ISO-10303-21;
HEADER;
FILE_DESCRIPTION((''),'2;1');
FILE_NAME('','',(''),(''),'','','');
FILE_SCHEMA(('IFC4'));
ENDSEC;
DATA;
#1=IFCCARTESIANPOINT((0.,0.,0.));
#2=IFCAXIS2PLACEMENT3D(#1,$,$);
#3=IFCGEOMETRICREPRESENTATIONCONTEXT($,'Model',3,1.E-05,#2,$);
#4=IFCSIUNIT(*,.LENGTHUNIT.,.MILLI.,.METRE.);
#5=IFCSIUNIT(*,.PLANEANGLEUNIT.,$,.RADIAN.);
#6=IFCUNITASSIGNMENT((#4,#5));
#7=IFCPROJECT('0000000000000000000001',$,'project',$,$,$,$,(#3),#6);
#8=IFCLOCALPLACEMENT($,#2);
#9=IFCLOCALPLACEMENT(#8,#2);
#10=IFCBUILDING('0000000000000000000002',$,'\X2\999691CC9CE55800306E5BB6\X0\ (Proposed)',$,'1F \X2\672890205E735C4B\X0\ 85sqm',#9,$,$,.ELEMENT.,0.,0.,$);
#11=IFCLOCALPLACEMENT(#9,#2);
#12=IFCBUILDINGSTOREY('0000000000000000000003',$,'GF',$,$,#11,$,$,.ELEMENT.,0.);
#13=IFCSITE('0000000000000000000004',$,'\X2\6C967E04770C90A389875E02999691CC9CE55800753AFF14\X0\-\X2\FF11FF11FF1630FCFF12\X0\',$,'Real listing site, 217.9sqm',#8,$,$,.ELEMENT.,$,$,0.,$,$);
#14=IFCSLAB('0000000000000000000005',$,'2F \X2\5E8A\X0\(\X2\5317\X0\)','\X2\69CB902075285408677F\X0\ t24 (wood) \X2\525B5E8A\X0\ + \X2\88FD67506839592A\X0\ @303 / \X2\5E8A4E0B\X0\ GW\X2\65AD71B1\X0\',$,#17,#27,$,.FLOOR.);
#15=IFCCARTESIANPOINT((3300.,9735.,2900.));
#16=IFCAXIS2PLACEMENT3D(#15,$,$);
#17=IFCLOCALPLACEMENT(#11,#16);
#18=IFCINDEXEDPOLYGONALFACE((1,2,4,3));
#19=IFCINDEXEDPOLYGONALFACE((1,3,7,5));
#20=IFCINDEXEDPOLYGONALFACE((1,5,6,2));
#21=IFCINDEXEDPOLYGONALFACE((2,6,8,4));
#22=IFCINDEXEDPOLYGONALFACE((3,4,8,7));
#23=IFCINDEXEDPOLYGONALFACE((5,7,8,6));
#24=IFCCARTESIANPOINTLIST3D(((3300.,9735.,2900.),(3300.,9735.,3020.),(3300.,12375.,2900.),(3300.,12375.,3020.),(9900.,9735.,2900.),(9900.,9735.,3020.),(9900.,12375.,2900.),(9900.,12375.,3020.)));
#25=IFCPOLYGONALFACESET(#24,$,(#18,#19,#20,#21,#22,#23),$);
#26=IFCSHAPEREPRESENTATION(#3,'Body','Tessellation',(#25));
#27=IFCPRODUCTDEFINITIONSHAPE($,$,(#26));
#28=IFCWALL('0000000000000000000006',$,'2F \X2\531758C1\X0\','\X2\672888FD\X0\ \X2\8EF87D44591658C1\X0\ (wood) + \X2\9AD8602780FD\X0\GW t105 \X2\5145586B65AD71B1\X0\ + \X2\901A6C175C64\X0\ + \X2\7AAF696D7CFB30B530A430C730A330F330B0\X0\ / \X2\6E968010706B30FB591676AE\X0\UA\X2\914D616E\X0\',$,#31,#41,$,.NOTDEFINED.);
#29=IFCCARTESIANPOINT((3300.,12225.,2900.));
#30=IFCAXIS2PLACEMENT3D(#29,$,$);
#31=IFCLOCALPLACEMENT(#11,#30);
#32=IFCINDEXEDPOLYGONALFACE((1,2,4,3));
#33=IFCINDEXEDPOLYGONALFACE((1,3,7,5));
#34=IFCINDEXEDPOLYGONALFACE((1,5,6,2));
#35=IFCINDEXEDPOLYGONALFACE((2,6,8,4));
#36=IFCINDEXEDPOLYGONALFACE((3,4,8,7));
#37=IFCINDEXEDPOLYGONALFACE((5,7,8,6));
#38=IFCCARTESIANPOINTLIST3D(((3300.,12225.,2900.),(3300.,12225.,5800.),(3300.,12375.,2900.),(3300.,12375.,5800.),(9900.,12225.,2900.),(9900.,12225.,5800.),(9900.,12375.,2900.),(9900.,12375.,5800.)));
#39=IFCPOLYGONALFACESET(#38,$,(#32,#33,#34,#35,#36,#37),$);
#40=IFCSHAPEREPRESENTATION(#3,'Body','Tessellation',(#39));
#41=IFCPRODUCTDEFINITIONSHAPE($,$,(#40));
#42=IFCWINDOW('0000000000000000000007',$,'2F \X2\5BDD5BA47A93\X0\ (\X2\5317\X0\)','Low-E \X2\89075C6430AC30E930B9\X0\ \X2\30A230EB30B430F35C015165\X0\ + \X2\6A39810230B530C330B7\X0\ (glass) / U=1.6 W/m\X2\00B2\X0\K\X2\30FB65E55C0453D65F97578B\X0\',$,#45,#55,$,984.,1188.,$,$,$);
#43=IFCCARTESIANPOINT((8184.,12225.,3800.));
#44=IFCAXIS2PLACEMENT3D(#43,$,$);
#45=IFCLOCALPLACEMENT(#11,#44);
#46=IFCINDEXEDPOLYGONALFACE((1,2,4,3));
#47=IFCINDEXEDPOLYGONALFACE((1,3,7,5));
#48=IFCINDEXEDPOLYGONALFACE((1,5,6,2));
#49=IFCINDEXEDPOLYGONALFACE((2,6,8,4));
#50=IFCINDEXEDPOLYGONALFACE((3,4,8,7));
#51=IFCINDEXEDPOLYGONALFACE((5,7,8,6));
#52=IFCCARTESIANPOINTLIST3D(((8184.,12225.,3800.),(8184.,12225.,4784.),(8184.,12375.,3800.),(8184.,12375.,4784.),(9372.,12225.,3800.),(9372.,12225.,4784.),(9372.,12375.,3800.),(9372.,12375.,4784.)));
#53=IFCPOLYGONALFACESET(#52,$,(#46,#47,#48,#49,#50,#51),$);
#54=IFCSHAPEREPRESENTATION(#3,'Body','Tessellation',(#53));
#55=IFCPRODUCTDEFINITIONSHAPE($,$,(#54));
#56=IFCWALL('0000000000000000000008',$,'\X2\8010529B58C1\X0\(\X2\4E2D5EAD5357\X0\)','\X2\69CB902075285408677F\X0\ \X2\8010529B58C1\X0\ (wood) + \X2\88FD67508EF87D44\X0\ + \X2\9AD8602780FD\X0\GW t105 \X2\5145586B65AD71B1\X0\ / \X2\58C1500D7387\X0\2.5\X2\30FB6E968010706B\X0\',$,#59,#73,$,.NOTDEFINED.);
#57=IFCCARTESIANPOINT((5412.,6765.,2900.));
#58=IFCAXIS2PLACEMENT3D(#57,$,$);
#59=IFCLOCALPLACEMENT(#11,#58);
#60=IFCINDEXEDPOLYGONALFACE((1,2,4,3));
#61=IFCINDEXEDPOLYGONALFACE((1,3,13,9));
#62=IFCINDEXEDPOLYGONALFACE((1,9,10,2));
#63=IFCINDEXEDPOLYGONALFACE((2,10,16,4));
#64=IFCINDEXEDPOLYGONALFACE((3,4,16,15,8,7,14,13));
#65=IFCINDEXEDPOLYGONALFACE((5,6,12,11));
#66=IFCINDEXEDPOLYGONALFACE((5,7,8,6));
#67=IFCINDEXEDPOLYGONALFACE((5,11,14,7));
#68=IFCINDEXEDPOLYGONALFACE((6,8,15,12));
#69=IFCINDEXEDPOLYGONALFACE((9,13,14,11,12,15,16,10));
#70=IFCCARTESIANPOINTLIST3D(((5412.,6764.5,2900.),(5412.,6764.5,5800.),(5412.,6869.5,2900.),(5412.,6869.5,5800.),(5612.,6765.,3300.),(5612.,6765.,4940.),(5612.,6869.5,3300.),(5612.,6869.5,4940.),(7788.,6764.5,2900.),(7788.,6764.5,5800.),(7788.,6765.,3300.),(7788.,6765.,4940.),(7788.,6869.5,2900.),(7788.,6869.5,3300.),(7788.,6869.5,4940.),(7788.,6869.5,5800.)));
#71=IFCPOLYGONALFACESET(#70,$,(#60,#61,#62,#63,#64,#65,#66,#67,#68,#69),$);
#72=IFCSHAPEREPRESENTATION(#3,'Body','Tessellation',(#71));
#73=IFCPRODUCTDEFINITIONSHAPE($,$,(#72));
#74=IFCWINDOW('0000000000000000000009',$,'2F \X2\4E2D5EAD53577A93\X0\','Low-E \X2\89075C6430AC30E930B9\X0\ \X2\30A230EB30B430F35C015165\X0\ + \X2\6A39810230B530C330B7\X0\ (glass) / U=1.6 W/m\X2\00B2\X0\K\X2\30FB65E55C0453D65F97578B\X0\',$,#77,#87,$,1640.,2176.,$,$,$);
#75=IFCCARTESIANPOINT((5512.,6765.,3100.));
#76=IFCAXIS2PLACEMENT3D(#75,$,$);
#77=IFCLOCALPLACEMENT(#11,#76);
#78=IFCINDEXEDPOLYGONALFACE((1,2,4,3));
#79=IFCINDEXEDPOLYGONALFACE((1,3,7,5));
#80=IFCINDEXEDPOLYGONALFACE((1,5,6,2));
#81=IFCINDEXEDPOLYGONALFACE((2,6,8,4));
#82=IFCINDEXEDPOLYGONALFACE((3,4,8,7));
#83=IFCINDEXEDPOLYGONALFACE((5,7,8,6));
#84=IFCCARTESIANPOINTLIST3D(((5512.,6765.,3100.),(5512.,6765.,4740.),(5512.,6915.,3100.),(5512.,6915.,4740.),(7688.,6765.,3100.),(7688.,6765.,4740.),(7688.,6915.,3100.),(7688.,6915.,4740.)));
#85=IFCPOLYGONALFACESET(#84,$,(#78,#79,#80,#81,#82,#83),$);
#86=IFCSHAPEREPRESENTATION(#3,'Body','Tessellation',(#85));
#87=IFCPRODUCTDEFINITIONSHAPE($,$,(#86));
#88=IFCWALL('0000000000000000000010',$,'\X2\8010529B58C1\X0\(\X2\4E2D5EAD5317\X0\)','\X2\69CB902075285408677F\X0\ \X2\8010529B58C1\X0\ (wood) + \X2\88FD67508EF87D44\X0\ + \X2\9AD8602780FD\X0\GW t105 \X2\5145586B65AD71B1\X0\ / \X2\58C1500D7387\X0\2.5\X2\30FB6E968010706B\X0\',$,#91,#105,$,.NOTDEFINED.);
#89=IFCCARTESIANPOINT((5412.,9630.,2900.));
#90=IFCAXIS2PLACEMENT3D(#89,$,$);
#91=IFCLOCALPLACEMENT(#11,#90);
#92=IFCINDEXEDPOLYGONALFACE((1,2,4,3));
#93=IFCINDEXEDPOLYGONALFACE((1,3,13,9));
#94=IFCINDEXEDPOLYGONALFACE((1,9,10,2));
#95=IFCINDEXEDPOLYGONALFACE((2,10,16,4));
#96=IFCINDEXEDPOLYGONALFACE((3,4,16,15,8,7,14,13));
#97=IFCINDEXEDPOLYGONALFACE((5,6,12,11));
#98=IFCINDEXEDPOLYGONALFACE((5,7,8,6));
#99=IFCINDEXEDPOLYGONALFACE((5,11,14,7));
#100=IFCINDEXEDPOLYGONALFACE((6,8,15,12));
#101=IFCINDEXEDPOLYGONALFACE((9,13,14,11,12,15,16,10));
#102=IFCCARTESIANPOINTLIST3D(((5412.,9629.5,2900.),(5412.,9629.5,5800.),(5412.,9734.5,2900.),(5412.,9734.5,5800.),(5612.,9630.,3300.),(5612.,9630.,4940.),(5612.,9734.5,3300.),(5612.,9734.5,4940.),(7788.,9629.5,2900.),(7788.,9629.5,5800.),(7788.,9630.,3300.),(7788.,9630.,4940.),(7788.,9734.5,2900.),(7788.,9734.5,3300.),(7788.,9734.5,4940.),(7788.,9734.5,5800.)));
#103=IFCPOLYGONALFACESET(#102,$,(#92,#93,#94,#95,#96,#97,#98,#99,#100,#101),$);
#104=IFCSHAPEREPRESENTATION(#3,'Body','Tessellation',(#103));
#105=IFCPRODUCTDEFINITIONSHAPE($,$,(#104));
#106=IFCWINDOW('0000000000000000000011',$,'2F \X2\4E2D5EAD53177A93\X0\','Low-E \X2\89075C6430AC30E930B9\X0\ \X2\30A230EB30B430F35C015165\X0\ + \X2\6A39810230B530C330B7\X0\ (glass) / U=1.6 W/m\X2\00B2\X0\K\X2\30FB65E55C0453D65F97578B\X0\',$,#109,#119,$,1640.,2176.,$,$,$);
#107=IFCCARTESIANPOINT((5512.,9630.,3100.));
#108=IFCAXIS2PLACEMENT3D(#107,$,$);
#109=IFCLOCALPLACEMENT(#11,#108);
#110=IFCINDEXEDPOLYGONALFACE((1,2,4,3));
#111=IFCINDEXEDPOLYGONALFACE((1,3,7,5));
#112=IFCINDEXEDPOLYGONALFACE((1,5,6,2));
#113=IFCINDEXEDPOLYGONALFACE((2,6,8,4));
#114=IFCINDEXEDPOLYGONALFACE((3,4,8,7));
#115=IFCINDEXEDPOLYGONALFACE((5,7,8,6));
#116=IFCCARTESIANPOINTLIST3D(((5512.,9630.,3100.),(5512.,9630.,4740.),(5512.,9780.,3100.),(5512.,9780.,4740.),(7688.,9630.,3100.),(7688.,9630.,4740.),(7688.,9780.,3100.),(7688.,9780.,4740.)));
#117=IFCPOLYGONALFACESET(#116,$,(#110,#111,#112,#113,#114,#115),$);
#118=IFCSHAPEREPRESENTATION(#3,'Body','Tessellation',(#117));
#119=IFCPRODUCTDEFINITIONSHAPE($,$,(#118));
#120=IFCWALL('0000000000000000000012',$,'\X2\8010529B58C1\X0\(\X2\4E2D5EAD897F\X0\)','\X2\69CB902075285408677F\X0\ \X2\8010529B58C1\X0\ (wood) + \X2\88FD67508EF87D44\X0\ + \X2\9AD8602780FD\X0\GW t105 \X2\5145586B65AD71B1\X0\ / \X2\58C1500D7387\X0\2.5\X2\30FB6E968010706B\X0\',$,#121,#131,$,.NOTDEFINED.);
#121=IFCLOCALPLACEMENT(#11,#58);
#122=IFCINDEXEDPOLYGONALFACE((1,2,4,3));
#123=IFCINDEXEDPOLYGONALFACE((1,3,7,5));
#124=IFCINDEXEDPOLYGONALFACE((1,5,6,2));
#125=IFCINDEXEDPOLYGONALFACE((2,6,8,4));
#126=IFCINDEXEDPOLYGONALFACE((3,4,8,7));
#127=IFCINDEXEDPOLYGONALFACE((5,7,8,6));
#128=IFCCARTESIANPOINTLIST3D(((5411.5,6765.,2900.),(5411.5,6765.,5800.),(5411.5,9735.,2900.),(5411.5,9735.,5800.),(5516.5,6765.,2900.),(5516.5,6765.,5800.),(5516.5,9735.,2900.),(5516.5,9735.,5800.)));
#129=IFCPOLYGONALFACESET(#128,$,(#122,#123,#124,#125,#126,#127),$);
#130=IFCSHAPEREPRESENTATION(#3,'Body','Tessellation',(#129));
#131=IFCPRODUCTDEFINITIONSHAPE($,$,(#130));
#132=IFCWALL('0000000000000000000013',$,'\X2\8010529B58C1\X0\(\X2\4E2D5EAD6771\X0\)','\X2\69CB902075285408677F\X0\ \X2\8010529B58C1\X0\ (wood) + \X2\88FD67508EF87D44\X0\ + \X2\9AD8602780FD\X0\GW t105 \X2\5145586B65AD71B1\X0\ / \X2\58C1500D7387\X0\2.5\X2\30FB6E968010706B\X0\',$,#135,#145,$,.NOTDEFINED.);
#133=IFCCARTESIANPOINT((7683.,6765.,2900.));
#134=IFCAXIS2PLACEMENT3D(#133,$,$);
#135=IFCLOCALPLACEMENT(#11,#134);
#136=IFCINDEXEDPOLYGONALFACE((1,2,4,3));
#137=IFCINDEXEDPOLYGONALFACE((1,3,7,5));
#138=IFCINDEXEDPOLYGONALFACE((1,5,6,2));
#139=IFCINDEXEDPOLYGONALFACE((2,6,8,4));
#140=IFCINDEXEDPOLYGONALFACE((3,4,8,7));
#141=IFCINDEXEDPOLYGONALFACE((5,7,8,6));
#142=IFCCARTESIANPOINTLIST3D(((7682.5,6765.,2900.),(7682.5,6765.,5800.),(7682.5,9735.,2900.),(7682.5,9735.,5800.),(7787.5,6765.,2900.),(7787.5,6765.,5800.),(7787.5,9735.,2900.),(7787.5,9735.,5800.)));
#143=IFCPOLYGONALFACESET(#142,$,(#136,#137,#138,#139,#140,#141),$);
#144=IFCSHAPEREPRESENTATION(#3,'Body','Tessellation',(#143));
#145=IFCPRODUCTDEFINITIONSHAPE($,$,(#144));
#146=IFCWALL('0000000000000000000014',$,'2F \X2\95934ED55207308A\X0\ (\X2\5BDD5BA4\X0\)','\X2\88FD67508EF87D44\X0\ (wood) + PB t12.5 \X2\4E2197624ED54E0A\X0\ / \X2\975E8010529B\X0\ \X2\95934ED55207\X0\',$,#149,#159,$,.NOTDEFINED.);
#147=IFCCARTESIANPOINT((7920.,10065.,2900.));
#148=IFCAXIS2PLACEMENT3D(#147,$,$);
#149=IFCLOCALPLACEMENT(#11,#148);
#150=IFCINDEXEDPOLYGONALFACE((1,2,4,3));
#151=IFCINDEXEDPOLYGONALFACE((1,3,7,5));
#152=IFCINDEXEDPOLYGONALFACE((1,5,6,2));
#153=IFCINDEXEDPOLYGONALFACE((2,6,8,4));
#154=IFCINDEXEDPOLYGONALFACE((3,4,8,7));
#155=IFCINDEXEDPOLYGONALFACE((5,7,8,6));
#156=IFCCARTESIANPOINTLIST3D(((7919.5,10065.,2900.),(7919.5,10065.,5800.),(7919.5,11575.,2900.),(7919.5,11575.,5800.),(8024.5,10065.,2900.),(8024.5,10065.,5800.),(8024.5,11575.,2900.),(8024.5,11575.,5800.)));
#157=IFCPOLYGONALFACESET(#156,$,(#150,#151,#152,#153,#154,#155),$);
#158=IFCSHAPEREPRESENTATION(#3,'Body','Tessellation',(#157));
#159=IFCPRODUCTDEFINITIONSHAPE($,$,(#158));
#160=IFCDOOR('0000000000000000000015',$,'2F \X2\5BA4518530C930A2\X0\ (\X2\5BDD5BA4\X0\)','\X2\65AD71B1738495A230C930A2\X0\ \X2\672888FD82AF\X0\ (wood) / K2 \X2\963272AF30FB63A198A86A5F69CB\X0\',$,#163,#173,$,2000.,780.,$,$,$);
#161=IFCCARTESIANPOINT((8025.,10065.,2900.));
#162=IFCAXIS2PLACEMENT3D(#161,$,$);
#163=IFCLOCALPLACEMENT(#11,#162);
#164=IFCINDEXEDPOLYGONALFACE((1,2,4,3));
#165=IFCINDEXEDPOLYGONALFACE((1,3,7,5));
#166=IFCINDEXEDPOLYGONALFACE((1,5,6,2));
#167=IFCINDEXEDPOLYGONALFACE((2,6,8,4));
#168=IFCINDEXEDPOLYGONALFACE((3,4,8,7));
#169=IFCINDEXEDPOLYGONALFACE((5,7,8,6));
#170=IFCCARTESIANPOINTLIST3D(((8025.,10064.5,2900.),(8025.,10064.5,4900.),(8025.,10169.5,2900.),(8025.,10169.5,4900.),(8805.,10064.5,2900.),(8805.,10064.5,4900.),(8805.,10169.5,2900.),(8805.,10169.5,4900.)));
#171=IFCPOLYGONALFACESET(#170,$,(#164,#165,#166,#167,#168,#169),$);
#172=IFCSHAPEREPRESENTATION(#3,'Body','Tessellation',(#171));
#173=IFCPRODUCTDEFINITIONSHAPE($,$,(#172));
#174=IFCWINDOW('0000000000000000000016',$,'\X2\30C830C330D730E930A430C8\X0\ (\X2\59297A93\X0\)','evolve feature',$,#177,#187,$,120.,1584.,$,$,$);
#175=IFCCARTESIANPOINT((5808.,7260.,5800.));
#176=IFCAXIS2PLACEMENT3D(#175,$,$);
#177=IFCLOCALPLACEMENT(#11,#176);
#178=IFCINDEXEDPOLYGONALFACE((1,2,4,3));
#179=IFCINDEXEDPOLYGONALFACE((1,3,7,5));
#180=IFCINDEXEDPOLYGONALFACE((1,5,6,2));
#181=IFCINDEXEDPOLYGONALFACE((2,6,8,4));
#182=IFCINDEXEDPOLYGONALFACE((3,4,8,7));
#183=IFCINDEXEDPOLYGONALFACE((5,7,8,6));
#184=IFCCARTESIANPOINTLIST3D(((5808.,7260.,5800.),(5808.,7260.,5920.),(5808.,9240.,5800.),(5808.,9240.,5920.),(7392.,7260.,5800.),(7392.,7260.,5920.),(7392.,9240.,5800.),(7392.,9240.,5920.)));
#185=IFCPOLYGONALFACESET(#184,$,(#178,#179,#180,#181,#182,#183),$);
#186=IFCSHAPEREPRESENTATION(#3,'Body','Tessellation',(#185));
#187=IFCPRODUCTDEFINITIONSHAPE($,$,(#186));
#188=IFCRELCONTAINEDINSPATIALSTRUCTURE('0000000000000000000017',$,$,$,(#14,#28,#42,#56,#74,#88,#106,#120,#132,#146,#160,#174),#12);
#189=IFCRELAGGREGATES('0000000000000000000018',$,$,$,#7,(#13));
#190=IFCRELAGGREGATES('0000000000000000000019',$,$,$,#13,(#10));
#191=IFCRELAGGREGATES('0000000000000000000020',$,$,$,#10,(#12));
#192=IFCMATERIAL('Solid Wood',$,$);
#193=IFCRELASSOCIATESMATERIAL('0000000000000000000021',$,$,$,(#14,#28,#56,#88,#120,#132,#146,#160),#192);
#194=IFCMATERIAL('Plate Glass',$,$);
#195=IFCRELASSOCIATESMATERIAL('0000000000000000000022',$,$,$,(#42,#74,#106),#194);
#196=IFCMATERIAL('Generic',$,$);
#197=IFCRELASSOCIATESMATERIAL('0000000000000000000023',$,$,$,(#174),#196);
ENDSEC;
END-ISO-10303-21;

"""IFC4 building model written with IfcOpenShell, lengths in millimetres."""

from ifc_helpers import new_model, si_unit, frame, frame_2d, origin, place, context, project, spatial, rectangle, extrude, material, element, fill, save


model = new_model("IFC4")

# Units and contexts
model_context = context("Model", 3, precision=1e-05, world=origin())
ifc_project = project(units=[si_unit("LENGTHUNIT", "METRE", prefix="MILLI"), si_unit("PLANEANGLEUNIT", "RADIAN")], contexts=[model_context])

# Site, building, storey
site_placement = place(None, origin())
site = spatial("IfcSite", under=ifc_project, at=site_placement, Name="沖縄県那覇市首里鳥堀町４-１１６ー２", ObjectType="Real listing site, 217.9sqm", CompositionType="ELEMENT", RefElevation=0.0)
building_placement = place(site_placement, origin())
building = spatial("IfcBuilding", under=site, at=building_placement, Name="首里鳥堀の家 (Proposed)", ObjectType="1F 木造平屋 85sqm", CompositionType="ELEMENT", ElevationOfRefHeight=0.0, ElevationOfTerrain=0.0)
storey_placement = place(building_placement, origin())
storey = spatial("IfcBuildingStorey", under=building, at=storey_placement, Name="GF", CompositionType="ELEMENT", Elevation=0.0)

# Slab
ifc_material_1 = material(Name="Solid Wood")
slab_placement = place(storey_placement, frame((3300.0, 9735.0, 2900.0)))
element("IfcSlab", 1, at=slab_placement, inside=storey, material=ifc_material_1, Name="2F 床(北)", Description="構造用合板 t24 (wood) 剛床 + 製材根太 @303 / 床下 GW断熱", PredefinedType="FLOOR", context=model_context, shape_type="SweptSolid", body=[
    extrude(rectangle(XDim=6600.0, YDim=2640.0, at=frame_2d((3300.0, 1320.0))), frame((3300.0, 9735.0, 2900.0)), (0.0, 0.0, 1.0), 120.0),
])

# Walls, openings, windows
wall_1_placement = place(storey_placement, frame((3300.0, 12225.0, 2900.0)))
wall_1 = element("IfcWall", 2, at=wall_1_placement, inside=storey, material=ifc_material_1, Name="2F 北壁", Description="木製 軸組外壁 (wood) + 高性能GW t105 充填断熱 + 通気層 + 窯業系サイディング / 準耐火・外皮UA配慮", PredefinedType="NOTDEFINED", context=model_context, shape_type="SweptSolid", body=[
    extrude(rectangle(XDim=6600.0, YDim=150.0, at=frame_2d((3300.0, 75.0))), frame((3300.0, 12225.0, 2900.0)), (0.0, 0.0, 1.0), 2900.0),
])
opening_1_placement = place(storey_placement, frame((8184.0, 12225.0, 3800.0)))
opening_1 = element("IfcOpeningElement", 3, at=opening_1_placement, cuts=wall_1, PredefinedType="NOTDEFINED", context=model_context, shape_type="SweptSolid", body=[
    extrude(rectangle(XDim=1188.0, YDim=150.0, at=frame_2d((594.0, 75.0))), frame((8184.0, 12225.0, 3800.0)), (0.0, 0.0, 1.0), 984.0),
])
ifc_material_2 = material(Name="Plate Glass")
window_1_placement = place(storey_placement, frame((8184.0, 12225.0, 3800.0)))
window_1 = element("IfcWindow", 4, at=window_1_placement, inside=storey, material=ifc_material_2, Name="2F 寝室窓 (北)", Description="Low-E 複層ガラス アルゴン封入 + 樹脂サッシ (glass) / U=1.6 W/m²K・日射取得型", OverallHeight=984.0, OverallWidth=1188.0, context=model_context, shape_type="SweptSolid", body=[
    extrude(rectangle(XDim=1188.0, YDim=150.0, at=frame_2d((594.0, 75.0))), frame((8184.0, 12225.0, 3800.0)), (0.0, 0.0, 1.0), 984.0),
])
fill(opening_1, window_1)
wall_2_placement = place(storey_placement, frame((5412.0, 6765.0, 2900.0)))
wall_2 = element("IfcWall", 5, at=wall_2_placement, inside=storey, material=ifc_material_1, Name="耐力壁(中庭南)", Description="構造用合板 耐力壁 (wood) + 製材軸組 + 高性能GW t105 充填断熱 / 壁倍率2.5・準耐火", PredefinedType="NOTDEFINED", context=model_context, shape_type="SweptSolid", body=[
    extrude(rectangle(XDim=2376.0, YDim=105.0, at=frame_2d((1188.0, 52.0))), frame((5412.0, 6765.0, 2900.0)), (0.0, 0.0, 1.0), 2900.0),
])
opening_2_placement = place(storey_placement, frame((5512.0, 6765.0, 3100.0)))
opening_2 = element("IfcOpeningElement", 6, at=opening_2_placement, cuts=wall_2, PredefinedType="NOTDEFINED", context=model_context, shape_type="SweptSolid", body=[
    extrude(rectangle(XDim=2176.0, YDim=150.0, at=frame_2d((1088.0, 75.0))), frame((5512.0, 6765.0, 3100.0)), (0.0, 0.0, 1.0), 1640.0),
])
window_2_placement = place(storey_placement, frame((5512.0, 6765.0, 3100.0)))
window_2 = element("IfcWindow", 7, at=window_2_placement, inside=storey, material=ifc_material_2, Name="2F 中庭南窓", Description="Low-E 複層ガラス アルゴン封入 + 樹脂サッシ (glass) / U=1.6 W/m²K・日射取得型", OverallHeight=1640.0, OverallWidth=2176.0, context=model_context, shape_type="SweptSolid", body=[
    extrude(rectangle(XDim=2176.0, YDim=150.0, at=frame_2d((1088.0, 75.0))), frame((5512.0, 6765.0, 3100.0)), (0.0, 0.0, 1.0), 1640.0),
])
fill(opening_2, window_2)
wall_3_placement = place(storey_placement, frame((5412.0, 9630.0, 2900.0)))
wall_3 = element("IfcWall", 8, at=wall_3_placement, inside=storey, material=ifc_material_1, Name="耐力壁(中庭北)", Description="構造用合板 耐力壁 (wood) + 製材軸組 + 高性能GW t105 充填断熱 / 壁倍率2.5・準耐火", PredefinedType="NOTDEFINED", context=model_context, shape_type="SweptSolid", body=[
    extrude(rectangle(XDim=2376.0, YDim=105.0, at=frame_2d((1188.0, 52.0))), frame((5412.0, 9630.0, 2900.0)), (0.0, 0.0, 1.0), 2900.0),
])
opening_3_placement = place(storey_placement, frame((5512.0, 9630.0, 3100.0)))
opening_3 = element("IfcOpeningElement", 9, at=opening_3_placement, cuts=wall_3, PredefinedType="NOTDEFINED", context=model_context, shape_type="SweptSolid", body=[
    extrude(rectangle(XDim=2176.0, YDim=150.0, at=frame_2d((1088.0, 75.0))), frame((5512.0, 9630.0, 3100.0)), (0.0, 0.0, 1.0), 1640.0),
])
window_3_placement = place(storey_placement, frame((5512.0, 9630.0, 3100.0)))
window_3 = element("IfcWindow", 10, at=window_3_placement, inside=storey, material=ifc_material_2, Name="2F 中庭北窓", Description="Low-E 複層ガラス アルゴン封入 + 樹脂サッシ (glass) / U=1.6 W/m²K・日射取得型", OverallHeight=1640.0, OverallWidth=2176.0, context=model_context, shape_type="SweptSolid", body=[
    extrude(rectangle(XDim=2176.0, YDim=150.0, at=frame_2d((1088.0, 75.0))), frame((5512.0, 9630.0, 3100.0)), (0.0, 0.0, 1.0), 1640.0),
])
fill(opening_3, window_3)

# Walls
wall_4_placement = place(storey_placement, frame((5412.0, 6765.0, 2900.0)))
element("IfcWall", 11, at=wall_4_placement, inside=storey, material=ifc_material_1, Name="耐力壁(中庭西)", Description="構造用合板 耐力壁 (wood) + 製材軸組 + 高性能GW t105 充填断熱 / 壁倍率2.5・準耐火", PredefinedType="NOTDEFINED", context=model_context, shape_type="SweptSolid", body=[
    extrude(rectangle(XDim=105.0, YDim=2970.0, at=frame_2d((52.0, 1485.0))), frame((5412.0, 6765.0, 2900.0)), (0.0, 0.0, 1.0), 2900.0),
])
wall_5_placement = place(storey_placement, frame((7683.0, 6765.0, 2900.0)))
element("IfcWall", 12, at=wall_5_placement, inside=storey, material=ifc_material_1, Name="耐力壁(中庭東)", Description="構造用合板 耐力壁 (wood) + 製材軸組 + 高性能GW t105 充填断熱 / 壁倍率2.5・準耐火", PredefinedType="NOTDEFINED", context=model_context, shape_type="SweptSolid", body=[
    extrude(rectangle(XDim=105.0, YDim=2970.0, at=frame_2d((52.0, 1485.0))), frame((7683.0, 6765.0, 2900.0)), (0.0, 0.0, 1.0), 2900.0),
])
wall_6_placement = place(storey_placement, frame((7920.0, 10065.0, 2900.0)))
element("IfcWall", 13, at=wall_6_placement, inside=storey, material=ifc_material_1, Name="2F 間仕切り (寝室)", Description="製材軸組 (wood) + PB t12.5 両面仕上 / 非耐力 間仕切", PredefinedType="NOTDEFINED", context=model_context, shape_type="SweptSolid", body=[
    extrude(rectangle(XDim=105.0, YDim=1510.0, at=frame_2d((52.0, 755.0))), frame((7920.0, 10065.0, 2900.0)), (0.0, 0.0, 1.0), 2900.0),
])

# Door
door_placement = place(storey_placement, frame((8025.0, 10065.0, 2900.0)))
element("IfcDoor", 14, at=door_placement, inside=storey, material=ifc_material_1, Name="2F 室内ドア (寝室)", Description="断熱玄関ドア 木製芯 (wood) / K2 防犯・採風機構", OverallHeight=2000.0, OverallWidth=780.0, context=model_context, shape_type="SweptSolid", body=[
    extrude(rectangle(XDim=780.0, YDim=105.0, at=frame_2d((390.0, 52.0))), frame((8025.0, 10065.0, 2900.0)), (0.0, 0.0, 1.0), 2000.0),
])

# Window
ifc_material_3 = material(Name="Generic")
window_4_placement = place(storey_placement, frame((5808.0, 7260.0, 5800.0)))
element("IfcWindow", 15, at=window_4_placement, inside=storey, material=ifc_material_3, Name="トップライト (天窓)", Description="evolve feature", OverallHeight=120.0, OverallWidth=1584.0, context=model_context, shape_type="SweptSolid", body=[
    extrude(rectangle(XDim=1584.0, YDim=1980.0, at=frame_2d((792.0, 990.0))), frame((5808.0, 7260.0, 5800.0)), (0.0, 0.0, 1.0), 120.0),
])

save(model, "model.ifc")
